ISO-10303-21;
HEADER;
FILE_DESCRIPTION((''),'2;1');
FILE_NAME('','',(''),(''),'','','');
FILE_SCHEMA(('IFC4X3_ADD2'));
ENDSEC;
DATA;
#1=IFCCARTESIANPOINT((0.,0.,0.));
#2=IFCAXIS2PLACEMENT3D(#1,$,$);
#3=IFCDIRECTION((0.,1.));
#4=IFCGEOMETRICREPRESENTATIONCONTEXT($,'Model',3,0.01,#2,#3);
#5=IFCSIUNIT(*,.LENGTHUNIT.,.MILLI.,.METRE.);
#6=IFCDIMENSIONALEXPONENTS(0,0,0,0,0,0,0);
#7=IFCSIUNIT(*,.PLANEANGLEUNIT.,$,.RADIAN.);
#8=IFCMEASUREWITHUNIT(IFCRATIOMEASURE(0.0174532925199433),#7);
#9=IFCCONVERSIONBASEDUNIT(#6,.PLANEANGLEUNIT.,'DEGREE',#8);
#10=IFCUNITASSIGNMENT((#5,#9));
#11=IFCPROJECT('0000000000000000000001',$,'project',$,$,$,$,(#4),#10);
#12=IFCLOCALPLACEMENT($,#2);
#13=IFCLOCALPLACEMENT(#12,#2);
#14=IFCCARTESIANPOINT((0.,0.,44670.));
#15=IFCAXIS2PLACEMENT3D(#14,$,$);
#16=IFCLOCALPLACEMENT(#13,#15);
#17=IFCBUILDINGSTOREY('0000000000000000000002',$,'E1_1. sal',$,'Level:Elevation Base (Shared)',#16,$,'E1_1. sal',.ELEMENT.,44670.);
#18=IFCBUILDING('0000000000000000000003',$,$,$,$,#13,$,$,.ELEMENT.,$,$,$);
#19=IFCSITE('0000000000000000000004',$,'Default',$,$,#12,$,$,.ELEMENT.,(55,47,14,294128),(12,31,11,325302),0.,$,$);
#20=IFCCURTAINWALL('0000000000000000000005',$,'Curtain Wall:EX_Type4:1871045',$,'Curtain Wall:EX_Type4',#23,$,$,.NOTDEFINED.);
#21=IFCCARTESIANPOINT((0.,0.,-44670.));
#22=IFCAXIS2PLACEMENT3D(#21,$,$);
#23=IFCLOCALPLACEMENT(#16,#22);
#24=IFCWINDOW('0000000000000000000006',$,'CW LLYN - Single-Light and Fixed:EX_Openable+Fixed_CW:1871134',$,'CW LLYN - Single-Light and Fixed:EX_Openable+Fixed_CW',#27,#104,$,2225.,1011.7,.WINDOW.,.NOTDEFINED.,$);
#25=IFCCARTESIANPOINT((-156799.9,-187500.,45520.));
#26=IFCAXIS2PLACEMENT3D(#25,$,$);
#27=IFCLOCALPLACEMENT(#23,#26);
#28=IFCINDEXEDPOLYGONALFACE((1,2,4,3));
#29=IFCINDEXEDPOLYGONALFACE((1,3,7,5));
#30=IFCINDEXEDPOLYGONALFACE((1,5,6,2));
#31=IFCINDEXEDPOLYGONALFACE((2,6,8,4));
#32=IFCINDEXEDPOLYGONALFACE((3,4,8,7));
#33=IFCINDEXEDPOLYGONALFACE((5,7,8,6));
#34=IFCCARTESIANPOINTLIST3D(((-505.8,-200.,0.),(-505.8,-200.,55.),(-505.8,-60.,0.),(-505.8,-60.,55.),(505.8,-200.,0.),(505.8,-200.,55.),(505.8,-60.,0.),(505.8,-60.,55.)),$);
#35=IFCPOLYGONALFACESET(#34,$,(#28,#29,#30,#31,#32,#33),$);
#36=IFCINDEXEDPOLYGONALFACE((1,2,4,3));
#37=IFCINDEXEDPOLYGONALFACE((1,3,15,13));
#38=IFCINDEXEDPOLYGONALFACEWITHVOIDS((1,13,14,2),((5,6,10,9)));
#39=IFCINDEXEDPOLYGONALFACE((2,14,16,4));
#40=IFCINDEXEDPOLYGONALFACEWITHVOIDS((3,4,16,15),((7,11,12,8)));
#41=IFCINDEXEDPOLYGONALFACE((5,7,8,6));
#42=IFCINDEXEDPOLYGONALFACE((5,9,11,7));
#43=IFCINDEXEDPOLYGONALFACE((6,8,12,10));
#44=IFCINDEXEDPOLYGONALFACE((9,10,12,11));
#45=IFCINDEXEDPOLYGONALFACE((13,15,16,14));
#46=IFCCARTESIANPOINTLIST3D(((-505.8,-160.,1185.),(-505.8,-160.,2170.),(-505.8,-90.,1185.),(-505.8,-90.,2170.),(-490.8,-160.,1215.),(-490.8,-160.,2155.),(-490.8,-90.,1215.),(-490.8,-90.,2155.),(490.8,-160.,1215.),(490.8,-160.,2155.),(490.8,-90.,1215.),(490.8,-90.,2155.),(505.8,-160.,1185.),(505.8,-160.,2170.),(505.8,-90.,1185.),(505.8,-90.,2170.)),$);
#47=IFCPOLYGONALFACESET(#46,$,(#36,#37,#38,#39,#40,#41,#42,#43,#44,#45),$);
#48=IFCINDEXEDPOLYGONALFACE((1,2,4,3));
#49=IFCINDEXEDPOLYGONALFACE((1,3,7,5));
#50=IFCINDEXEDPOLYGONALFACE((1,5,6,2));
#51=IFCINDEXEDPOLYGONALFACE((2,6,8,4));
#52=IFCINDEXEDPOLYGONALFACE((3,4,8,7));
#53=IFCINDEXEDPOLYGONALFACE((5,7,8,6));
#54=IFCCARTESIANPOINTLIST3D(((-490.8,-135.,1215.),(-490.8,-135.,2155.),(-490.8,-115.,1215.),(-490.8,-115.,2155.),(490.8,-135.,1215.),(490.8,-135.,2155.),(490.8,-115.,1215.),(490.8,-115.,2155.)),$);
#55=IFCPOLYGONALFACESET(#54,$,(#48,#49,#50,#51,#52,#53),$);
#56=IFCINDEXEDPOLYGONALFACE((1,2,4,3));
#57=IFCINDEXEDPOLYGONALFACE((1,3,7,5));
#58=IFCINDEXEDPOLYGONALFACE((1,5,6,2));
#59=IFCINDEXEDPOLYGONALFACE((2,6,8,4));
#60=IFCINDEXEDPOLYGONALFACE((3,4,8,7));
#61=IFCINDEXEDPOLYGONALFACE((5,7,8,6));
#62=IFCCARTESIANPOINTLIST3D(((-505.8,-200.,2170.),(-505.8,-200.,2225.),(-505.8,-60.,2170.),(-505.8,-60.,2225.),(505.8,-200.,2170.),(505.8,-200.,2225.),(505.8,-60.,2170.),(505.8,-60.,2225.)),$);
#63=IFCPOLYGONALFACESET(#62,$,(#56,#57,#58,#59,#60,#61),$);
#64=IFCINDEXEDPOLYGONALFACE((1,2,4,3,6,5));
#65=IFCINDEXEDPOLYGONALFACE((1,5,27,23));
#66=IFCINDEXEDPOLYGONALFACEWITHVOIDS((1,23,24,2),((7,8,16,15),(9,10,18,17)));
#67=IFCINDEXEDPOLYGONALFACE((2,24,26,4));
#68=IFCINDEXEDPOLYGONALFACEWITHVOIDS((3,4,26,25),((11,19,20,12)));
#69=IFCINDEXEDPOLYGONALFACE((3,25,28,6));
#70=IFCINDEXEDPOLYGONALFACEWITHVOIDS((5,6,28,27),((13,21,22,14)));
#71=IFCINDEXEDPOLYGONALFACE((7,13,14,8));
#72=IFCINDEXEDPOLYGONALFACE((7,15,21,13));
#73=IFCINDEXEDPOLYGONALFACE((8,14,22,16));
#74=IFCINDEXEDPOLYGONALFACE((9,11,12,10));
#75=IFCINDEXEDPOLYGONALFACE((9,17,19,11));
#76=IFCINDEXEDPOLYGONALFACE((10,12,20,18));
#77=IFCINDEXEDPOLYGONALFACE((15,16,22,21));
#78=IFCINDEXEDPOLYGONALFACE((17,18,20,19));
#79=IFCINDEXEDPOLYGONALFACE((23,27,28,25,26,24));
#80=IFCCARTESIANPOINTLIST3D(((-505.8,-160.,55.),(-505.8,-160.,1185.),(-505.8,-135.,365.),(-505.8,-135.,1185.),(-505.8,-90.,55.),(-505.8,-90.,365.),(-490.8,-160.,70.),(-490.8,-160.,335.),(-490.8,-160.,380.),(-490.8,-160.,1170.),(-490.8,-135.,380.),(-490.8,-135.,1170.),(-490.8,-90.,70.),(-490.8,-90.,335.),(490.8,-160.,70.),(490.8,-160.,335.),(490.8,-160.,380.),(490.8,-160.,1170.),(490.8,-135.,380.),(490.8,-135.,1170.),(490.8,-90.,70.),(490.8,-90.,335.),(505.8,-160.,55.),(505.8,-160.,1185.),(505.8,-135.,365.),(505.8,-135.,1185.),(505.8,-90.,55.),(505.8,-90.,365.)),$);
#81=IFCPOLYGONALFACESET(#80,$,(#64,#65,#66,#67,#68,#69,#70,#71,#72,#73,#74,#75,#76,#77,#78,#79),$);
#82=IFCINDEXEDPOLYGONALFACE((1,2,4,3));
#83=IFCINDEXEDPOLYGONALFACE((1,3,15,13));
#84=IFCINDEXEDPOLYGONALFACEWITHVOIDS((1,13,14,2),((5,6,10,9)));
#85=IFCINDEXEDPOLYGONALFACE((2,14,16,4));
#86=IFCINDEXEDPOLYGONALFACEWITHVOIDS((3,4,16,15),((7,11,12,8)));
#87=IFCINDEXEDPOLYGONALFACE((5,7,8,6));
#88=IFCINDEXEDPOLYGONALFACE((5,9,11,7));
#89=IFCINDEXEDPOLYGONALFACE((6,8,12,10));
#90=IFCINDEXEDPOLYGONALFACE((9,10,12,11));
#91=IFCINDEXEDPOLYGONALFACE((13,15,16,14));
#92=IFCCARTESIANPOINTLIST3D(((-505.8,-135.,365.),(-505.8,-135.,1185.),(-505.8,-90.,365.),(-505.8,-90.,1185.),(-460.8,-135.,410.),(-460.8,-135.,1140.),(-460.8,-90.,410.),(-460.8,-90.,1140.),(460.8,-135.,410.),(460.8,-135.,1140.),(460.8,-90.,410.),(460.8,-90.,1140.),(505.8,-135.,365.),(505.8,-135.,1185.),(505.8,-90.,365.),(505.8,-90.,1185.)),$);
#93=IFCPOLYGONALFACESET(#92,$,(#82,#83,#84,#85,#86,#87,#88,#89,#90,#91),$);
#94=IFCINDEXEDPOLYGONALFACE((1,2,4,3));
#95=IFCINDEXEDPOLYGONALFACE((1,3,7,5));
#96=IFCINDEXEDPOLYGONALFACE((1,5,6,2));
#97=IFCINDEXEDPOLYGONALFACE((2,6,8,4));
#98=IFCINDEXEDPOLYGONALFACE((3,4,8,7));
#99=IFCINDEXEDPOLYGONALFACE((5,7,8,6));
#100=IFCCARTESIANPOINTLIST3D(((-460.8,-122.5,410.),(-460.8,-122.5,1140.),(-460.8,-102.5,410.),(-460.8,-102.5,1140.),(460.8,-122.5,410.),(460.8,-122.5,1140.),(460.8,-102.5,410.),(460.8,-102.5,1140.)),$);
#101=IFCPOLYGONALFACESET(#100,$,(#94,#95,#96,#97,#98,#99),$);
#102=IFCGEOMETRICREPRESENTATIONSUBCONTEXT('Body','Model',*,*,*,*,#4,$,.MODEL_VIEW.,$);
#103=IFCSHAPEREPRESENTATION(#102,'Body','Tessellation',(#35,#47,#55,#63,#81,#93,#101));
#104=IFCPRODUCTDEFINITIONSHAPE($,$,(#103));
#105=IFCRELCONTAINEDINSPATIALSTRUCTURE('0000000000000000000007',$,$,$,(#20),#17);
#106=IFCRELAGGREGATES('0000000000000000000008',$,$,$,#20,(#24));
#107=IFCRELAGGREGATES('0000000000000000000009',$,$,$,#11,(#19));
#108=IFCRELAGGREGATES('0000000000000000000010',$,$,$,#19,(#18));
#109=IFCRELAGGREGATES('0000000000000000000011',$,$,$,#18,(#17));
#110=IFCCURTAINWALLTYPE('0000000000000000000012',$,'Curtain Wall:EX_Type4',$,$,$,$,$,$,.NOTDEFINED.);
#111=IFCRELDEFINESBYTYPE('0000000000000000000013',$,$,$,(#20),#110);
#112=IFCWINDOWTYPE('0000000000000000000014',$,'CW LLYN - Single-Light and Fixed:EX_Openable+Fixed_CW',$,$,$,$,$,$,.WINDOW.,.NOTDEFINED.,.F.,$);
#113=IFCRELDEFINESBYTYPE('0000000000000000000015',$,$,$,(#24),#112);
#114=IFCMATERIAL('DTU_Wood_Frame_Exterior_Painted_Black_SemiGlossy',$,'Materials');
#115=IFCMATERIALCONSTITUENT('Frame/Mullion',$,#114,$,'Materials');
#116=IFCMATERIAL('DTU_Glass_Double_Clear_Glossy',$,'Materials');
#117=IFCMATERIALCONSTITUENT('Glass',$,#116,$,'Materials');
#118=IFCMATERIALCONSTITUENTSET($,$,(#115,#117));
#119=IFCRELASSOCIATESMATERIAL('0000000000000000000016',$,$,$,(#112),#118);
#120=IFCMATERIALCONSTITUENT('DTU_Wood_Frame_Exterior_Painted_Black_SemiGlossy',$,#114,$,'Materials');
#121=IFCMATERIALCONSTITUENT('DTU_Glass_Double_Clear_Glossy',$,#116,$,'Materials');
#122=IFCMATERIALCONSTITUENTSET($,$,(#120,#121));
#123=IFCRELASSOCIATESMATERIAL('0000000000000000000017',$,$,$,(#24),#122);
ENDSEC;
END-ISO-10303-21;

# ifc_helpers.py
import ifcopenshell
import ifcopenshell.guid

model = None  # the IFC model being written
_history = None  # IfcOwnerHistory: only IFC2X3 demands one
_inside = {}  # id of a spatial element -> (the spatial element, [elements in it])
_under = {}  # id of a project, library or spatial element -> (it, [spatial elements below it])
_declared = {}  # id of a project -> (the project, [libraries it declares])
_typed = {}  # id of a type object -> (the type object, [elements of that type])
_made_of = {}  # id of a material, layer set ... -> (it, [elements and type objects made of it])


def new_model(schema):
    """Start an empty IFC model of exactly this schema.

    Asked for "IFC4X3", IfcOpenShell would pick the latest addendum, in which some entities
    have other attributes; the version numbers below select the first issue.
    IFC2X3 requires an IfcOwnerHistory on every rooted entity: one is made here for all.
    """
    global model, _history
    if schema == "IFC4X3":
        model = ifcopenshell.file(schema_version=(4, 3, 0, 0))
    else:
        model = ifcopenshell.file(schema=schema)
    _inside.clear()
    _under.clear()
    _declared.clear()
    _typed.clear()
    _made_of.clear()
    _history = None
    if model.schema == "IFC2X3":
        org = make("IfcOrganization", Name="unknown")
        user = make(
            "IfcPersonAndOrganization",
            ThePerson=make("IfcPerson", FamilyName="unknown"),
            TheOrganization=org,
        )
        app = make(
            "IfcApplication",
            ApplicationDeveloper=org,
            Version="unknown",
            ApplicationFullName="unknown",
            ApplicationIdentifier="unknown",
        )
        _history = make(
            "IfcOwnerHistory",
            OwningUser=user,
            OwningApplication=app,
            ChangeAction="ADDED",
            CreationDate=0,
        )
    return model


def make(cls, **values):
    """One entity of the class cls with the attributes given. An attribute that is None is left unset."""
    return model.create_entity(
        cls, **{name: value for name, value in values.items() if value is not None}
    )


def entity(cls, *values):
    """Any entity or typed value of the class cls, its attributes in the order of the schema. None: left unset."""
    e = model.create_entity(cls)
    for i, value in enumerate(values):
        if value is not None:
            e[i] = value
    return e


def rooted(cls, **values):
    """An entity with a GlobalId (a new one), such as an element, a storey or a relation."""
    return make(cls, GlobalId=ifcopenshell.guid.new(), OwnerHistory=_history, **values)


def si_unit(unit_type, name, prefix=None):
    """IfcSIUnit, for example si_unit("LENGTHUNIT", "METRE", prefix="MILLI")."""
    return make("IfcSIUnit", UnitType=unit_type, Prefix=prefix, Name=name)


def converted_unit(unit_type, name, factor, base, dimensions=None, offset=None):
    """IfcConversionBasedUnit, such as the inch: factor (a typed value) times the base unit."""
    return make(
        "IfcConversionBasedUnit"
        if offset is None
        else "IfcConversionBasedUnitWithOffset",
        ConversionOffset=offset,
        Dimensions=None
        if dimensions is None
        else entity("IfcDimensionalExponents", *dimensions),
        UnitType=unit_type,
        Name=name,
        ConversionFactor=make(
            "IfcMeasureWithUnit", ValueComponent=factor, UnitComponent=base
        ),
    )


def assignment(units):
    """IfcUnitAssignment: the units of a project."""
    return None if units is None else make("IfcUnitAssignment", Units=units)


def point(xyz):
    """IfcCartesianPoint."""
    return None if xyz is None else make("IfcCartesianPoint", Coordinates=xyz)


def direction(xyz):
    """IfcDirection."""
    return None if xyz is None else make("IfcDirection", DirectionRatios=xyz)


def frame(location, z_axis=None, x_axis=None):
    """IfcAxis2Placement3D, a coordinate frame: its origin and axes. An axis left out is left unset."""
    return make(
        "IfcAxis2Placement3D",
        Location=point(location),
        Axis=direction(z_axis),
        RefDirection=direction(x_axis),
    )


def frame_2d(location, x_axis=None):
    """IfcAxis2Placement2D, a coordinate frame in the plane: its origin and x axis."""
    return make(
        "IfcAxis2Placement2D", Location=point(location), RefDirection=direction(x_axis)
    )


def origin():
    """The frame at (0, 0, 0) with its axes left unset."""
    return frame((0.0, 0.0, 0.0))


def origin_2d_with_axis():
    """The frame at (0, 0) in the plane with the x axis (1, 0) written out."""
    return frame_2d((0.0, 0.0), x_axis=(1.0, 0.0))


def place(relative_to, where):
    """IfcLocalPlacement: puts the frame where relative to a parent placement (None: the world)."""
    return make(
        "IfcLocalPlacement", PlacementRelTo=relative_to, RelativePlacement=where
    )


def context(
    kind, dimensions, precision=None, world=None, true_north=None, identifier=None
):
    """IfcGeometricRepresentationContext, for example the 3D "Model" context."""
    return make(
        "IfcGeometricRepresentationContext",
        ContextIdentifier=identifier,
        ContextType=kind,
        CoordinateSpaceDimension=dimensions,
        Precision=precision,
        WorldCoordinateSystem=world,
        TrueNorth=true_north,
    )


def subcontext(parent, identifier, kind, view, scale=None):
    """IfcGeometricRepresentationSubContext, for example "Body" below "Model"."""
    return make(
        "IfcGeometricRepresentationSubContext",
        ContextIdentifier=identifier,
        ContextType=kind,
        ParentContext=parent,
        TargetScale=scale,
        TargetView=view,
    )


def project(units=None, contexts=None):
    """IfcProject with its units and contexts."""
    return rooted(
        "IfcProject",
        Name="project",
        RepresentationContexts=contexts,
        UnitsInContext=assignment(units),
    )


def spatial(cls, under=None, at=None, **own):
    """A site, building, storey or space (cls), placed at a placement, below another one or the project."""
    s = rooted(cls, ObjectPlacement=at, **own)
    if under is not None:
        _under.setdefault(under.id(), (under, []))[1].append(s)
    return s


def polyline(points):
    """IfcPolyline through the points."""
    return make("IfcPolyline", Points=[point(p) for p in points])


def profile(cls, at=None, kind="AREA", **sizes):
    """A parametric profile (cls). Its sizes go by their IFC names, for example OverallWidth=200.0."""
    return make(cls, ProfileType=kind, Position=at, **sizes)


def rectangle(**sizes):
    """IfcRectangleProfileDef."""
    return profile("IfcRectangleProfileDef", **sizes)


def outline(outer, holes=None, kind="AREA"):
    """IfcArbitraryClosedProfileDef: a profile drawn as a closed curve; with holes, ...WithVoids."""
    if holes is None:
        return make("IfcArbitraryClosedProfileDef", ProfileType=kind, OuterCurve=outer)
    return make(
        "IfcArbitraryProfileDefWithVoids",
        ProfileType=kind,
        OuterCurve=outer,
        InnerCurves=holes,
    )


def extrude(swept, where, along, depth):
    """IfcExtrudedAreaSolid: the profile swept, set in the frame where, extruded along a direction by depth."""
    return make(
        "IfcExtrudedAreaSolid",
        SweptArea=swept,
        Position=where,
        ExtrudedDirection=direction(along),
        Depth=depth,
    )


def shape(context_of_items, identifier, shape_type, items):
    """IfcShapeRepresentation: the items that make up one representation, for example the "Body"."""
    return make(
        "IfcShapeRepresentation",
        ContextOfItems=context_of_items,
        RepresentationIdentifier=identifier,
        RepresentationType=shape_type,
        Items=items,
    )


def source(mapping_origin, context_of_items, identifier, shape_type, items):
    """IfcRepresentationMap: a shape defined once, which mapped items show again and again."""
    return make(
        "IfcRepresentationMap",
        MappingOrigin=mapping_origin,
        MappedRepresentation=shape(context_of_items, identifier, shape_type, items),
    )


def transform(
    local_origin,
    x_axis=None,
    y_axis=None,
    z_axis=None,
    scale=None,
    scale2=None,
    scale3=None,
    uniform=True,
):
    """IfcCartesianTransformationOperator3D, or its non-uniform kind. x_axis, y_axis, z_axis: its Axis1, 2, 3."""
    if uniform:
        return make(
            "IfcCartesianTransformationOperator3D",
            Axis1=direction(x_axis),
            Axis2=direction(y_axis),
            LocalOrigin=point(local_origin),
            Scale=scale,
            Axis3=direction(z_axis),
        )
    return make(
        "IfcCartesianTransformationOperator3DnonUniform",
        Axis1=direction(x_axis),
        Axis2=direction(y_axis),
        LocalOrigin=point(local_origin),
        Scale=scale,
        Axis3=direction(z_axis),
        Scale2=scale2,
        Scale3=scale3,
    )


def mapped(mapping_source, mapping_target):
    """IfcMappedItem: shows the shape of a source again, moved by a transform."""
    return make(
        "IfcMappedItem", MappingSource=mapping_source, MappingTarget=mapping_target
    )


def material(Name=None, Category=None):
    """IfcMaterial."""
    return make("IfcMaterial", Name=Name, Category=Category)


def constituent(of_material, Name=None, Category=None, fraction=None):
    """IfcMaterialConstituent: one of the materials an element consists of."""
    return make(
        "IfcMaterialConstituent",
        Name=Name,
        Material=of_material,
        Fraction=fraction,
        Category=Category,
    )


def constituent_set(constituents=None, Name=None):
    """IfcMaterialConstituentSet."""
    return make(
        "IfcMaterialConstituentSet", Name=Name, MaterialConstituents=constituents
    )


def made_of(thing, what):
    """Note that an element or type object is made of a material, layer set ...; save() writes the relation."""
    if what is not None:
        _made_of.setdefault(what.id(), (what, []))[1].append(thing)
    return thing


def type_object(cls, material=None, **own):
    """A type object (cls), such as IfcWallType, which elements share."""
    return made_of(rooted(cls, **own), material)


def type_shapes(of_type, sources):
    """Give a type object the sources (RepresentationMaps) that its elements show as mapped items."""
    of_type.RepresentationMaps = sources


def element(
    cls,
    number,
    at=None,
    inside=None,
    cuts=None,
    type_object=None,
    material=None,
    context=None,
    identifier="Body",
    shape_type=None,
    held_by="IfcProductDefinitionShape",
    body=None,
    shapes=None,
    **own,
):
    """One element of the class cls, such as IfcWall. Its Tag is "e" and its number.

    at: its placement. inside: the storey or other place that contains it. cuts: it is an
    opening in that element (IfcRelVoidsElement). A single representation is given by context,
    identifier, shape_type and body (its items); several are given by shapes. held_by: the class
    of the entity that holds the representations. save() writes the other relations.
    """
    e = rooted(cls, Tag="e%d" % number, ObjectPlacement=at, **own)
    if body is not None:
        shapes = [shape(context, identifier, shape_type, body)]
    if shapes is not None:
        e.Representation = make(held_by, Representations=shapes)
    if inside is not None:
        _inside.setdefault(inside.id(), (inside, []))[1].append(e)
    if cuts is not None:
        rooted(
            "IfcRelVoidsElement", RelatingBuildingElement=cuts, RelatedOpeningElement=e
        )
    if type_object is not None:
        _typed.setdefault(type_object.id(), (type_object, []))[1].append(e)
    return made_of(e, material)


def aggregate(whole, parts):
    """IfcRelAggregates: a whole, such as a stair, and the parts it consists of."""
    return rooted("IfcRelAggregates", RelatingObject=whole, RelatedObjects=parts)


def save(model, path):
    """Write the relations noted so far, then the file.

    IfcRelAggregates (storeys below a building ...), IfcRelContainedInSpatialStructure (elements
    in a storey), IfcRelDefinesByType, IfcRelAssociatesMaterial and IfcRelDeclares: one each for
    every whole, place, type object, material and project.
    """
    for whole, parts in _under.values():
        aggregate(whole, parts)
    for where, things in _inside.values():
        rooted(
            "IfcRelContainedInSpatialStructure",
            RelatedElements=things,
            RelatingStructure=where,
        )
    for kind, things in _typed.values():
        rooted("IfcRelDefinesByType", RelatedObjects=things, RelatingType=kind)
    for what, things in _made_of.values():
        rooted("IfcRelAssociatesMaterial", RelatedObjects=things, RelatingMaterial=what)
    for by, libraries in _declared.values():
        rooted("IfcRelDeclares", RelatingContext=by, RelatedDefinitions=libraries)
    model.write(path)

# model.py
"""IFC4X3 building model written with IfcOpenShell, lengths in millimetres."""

from ifc_helpers import new_model, entity, si_unit, converted_unit, direction, frame, frame_2d, origin, origin_2d_with_axis, place, context, subcontext, project, spatial, polyline, rectangle, outline, extrude, source, transform, mapped, material, constituent, constituent_set, type_object, type_shapes, element, aggregate, save


model = new_model("IFC4X3")

# Units and contexts
model_context = context("Model", 3, precision=0.01, world=origin(), true_north=direction((0.0, 1.0)))
body_context = subcontext(model_context, "Body", "Model", "MODEL_VIEW")
ifc_project = project(units=[si_unit("LENGTHUNIT", "METRE", prefix="MILLI"), converted_unit("PLANEANGLEUNIT", "DEGREE", entity("IfcRatioMeasure", 0.0174532925199433), si_unit("PLANEANGLEUNIT", "RADIAN"), dimensions=[0, 0, 0, 0, 0, 0, 0])], contexts=[model_context])

# Site, building, storey
site_placement = place(None, origin())
site = spatial("IfcSite", under=ifc_project, at=site_placement, Name="Default", CompositionType="ELEMENT", RefLatitude=(55, 47, 14, 294128), RefLongitude=(12, 31, 11, 325302), RefElevation=0.0)
building_placement = place(site_placement, origin())
building = spatial("IfcBuilding", under=site, at=building_placement, CompositionType="ELEMENT")
storey_placement = place(building_placement, frame((0.0, 0.0, 44670.0)))
storey = spatial("IfcBuildingStorey", under=building, at=storey_placement, Name="E1_1. sal", ObjectType="Level:Elevation Base (Shared)", LongName="E1_1. sal", CompositionType="ELEMENT", Elevation=44670.0)

# Curtain wall, window, openings
curtain_wall_type = type_object("IfcCurtainWallType", Name="Curtain Wall:EX_Type4", PredefinedType="NOTDEFINED")
curtain_wall_placement = place(storey_placement, frame((0.0, 0.0, -44670.0)))
curtain_wall = element("IfcCurtainWall", 1, at=curtain_wall_placement, inside=storey, type_object=curtain_wall_type, Name="Curtain Wall:EX_Type4:1871045", ObjectType="Curtain Wall:EX_Type4", PredefinedType="NOTDEFINED")
ifc_material_1 = material(Name="DTU_Wood_Frame_Exterior_Painted_Black_SemiGlossy", Category="Materials")
ifc_material_2 = material(Name="DTU_Glass_Double_Clear_Glossy", Category="Materials")
ifc_constituent_1 = constituent(ifc_material_1, Name="DTU_Wood_Frame_Exterior_Painted_Black_SemiGlossy", Category="Materials")
ifc_constituent_2 = constituent(ifc_material_2, Name="DTU_Glass_Double_Clear_Glossy", Category="Materials")
ifc_constituent_set_1 = constituent_set(constituents=[ifc_constituent_1, ifc_constituent_2])
ifc_constituent_3 = constituent(ifc_material_1, Name="Frame/Mullion", Category="Materials")
ifc_constituent_4 = constituent(ifc_material_2, Name="Glass", Category="Materials")
ifc_constituent_set_2 = constituent_set(constituents=[ifc_constituent_3, ifc_constituent_4])
window_type_1 = type_object("IfcWindowType", Name="CW LLYN - Single-Light and Fixed:EX_Openable+Fixed_CW", ParameterTakesPrecedence=False, PartitioningType="NOTDEFINED", PredefinedType="WINDOW", material=ifc_constituent_set_2)
shared_shape_1 = source(origin(), body_context, "Body", "SweptSolid", [
    extrude(rectangle(XDim=140.0, YDim=1011.7, at=origin_2d_with_axis()), frame((0.0, -130.0, 0.0), z_axis=(0.0, 0.0, 1.0), x_axis=(0.0, -1.0, 0.0)), (0.0, 0.0, 1.0), 55.0),
    extrude(outline(polyline([(-492.5, -505.8), (492.5, -505.8), (492.5, 505.8), (-492.5, 505.8), (-492.5, -505.8)]), holes=[polyline([(477.5, -490.8), (-462.5, -490.8), (-462.5, 490.8), (477.5, 490.8), (477.5, -490.8)])]), frame((0.0, -90.0, 1677.5), z_axis=(0.0, -1.0, 0.0), x_axis=(0.0, 0.0, 1.0)), (0.0, 0.0, 1.0), 70.0),
    extrude(rectangle(XDim=981.7, YDim=20.0, at=frame_2d((0.0, 0.0), x_axis=(1.0, 0.0))), frame((0.0, -125.0, 1215.0), z_axis=(0.0, 0.0, 1.0), x_axis=(-1.0, 0.0, 0.0)), (0.0, 0.0, 1.0), 940.0),
    extrude(rectangle(XDim=981.7, YDim=20.0, at=frame_2d((0.0, 0.0), x_axis=(1.0, 0.0))), frame((0.0, -125.0, 70.0), z_axis=(0.0, 0.0, 1.0), x_axis=(-1.0, 0.0, 0.0)), (0.0, 0.0, 1.0), 265.0),
    extrude(rectangle(XDim=140.0, YDim=1011.7, at=frame_2d((0.0, 0.0), x_axis=(1.0, 0.0))), frame((0.0, -130.0, 2170.0), z_axis=(0.0, 0.0, 1.0), x_axis=(0.0, -1.0, 0.0)), (0.0, 0.0, 1.0), 55.0),
    extrude(outline(polyline([(-38.3, -480.0), (31.7, -480.0), (31.7, 650.0), (6.7, 650.0), (6.7, -170.0), (-38.3, -170.0), (-38.3, -480.0)])), frame((505.8, -128.3, 535.0), z_axis=(-1.0, 0.0, 0.0), x_axis=(0.0, -1.0, 0.0)), (0.0, 0.0, 1.0), 1011.7),
    extrude(outline(polyline([(-410.0, -505.8), (410.0, -505.8), (410.0, 505.8), (-410.0, 505.8), (-410.0, -505.8)]), holes=[polyline([(-365.0, 460.8), (365.0, 460.8), (365.0, -460.8), (-365.0, -460.8), (-365.0, 460.8)])]), frame((0.0, -90.0, 775.0), z_axis=(0.0, -1.0, 0.0), x_axis=(0.0, 0.0, 1.0)), (0.0, 0.0, 1.0), 45.0),
    extrude(rectangle(XDim=921.7, YDim=20.0, at=frame_2d((0.0, 0.0), x_axis=(1.0, 0.0))), frame((0.0, -112.5, 410.0), z_axis=(0.0, 0.0, 1.0), x_axis=(-1.0, 0.0, 0.0)), (0.0, 0.0, 1.0), 730.0),
])
type_shapes(window_type_1, [shared_shape_1])
window_1_placement = place(curtain_wall_placement, frame((-156799.9, -187500.0, 45520.0)))
window_1 = element("IfcWindow", 2, at=window_1_placement, type_object=window_type_1, material=ifc_constituent_set_1, Name="CW LLYN - Single-Light and Fixed:EX_Openable+Fixed_CW:1871134", ObjectType="CW LLYN - Single-Light and Fixed:EX_Openable+Fixed_CW", OverallHeight=2225.0, OverallWidth=1011.7, PartitioningType="NOTDEFINED", PredefinedType="WINDOW", context=body_context, shape_type="MappedRepresentation", body=[
    mapped(shared_shape_1, transform((0.0, 0.0, 0.0), scale=1.0)),
])
opening_1_placement = place(curtain_wall_placement, frame((-156799.9, -187500.0, 90190.0), z_axis=(0.0, 0.0, 1.0), x_axis=(-1.0, 0.0, 0.0)))
opening_1 = element("IfcOpeningElement", 3, at=opening_1_placement, cuts=window_1, PredefinedType="OPENING", context=body_context, shape_type="SweptSolid", body=[
    extrude(rectangle(XDim=265.0, YDim=981.7, at=frame_2d((0.0, 0.0), x_axis=(1.0, 0.0))), frame((0.0, 160.0, -44467.5), z_axis=(0.0, -1.0, 0.0), x_axis=(0.0, 0.0, 1.0)), (0.0, 0.0, 1.0), 70.0),
])
opening_2_placement = place(curtain_wall_placement, frame((-156799.9, -187500.0, 90190.0), z_axis=(0.0, 0.0, 1.0), x_axis=(-1.0, 0.0, 0.0)))
opening_2 = element("IfcOpeningElement", 4, at=opening_2_placement, cuts=window_1, PredefinedType="OPENING", context=body_context, shape_type="SweptSolid", body=[
    extrude(rectangle(XDim=790.0, YDim=981.7, at=frame_2d((0.0, 0.0), x_axis=(1.0, 0.0))), frame((0.0, 135.0, -43895.0), z_axis=(0.0, 1.0, 0.0), x_axis=(0.0, 0.0, 1.0)), (0.0, 0.0, 1.0), 25.0),
])
aggregate(curtain_wall, [window_1, opening_1, opening_2])

save(model, "model.ifc")
